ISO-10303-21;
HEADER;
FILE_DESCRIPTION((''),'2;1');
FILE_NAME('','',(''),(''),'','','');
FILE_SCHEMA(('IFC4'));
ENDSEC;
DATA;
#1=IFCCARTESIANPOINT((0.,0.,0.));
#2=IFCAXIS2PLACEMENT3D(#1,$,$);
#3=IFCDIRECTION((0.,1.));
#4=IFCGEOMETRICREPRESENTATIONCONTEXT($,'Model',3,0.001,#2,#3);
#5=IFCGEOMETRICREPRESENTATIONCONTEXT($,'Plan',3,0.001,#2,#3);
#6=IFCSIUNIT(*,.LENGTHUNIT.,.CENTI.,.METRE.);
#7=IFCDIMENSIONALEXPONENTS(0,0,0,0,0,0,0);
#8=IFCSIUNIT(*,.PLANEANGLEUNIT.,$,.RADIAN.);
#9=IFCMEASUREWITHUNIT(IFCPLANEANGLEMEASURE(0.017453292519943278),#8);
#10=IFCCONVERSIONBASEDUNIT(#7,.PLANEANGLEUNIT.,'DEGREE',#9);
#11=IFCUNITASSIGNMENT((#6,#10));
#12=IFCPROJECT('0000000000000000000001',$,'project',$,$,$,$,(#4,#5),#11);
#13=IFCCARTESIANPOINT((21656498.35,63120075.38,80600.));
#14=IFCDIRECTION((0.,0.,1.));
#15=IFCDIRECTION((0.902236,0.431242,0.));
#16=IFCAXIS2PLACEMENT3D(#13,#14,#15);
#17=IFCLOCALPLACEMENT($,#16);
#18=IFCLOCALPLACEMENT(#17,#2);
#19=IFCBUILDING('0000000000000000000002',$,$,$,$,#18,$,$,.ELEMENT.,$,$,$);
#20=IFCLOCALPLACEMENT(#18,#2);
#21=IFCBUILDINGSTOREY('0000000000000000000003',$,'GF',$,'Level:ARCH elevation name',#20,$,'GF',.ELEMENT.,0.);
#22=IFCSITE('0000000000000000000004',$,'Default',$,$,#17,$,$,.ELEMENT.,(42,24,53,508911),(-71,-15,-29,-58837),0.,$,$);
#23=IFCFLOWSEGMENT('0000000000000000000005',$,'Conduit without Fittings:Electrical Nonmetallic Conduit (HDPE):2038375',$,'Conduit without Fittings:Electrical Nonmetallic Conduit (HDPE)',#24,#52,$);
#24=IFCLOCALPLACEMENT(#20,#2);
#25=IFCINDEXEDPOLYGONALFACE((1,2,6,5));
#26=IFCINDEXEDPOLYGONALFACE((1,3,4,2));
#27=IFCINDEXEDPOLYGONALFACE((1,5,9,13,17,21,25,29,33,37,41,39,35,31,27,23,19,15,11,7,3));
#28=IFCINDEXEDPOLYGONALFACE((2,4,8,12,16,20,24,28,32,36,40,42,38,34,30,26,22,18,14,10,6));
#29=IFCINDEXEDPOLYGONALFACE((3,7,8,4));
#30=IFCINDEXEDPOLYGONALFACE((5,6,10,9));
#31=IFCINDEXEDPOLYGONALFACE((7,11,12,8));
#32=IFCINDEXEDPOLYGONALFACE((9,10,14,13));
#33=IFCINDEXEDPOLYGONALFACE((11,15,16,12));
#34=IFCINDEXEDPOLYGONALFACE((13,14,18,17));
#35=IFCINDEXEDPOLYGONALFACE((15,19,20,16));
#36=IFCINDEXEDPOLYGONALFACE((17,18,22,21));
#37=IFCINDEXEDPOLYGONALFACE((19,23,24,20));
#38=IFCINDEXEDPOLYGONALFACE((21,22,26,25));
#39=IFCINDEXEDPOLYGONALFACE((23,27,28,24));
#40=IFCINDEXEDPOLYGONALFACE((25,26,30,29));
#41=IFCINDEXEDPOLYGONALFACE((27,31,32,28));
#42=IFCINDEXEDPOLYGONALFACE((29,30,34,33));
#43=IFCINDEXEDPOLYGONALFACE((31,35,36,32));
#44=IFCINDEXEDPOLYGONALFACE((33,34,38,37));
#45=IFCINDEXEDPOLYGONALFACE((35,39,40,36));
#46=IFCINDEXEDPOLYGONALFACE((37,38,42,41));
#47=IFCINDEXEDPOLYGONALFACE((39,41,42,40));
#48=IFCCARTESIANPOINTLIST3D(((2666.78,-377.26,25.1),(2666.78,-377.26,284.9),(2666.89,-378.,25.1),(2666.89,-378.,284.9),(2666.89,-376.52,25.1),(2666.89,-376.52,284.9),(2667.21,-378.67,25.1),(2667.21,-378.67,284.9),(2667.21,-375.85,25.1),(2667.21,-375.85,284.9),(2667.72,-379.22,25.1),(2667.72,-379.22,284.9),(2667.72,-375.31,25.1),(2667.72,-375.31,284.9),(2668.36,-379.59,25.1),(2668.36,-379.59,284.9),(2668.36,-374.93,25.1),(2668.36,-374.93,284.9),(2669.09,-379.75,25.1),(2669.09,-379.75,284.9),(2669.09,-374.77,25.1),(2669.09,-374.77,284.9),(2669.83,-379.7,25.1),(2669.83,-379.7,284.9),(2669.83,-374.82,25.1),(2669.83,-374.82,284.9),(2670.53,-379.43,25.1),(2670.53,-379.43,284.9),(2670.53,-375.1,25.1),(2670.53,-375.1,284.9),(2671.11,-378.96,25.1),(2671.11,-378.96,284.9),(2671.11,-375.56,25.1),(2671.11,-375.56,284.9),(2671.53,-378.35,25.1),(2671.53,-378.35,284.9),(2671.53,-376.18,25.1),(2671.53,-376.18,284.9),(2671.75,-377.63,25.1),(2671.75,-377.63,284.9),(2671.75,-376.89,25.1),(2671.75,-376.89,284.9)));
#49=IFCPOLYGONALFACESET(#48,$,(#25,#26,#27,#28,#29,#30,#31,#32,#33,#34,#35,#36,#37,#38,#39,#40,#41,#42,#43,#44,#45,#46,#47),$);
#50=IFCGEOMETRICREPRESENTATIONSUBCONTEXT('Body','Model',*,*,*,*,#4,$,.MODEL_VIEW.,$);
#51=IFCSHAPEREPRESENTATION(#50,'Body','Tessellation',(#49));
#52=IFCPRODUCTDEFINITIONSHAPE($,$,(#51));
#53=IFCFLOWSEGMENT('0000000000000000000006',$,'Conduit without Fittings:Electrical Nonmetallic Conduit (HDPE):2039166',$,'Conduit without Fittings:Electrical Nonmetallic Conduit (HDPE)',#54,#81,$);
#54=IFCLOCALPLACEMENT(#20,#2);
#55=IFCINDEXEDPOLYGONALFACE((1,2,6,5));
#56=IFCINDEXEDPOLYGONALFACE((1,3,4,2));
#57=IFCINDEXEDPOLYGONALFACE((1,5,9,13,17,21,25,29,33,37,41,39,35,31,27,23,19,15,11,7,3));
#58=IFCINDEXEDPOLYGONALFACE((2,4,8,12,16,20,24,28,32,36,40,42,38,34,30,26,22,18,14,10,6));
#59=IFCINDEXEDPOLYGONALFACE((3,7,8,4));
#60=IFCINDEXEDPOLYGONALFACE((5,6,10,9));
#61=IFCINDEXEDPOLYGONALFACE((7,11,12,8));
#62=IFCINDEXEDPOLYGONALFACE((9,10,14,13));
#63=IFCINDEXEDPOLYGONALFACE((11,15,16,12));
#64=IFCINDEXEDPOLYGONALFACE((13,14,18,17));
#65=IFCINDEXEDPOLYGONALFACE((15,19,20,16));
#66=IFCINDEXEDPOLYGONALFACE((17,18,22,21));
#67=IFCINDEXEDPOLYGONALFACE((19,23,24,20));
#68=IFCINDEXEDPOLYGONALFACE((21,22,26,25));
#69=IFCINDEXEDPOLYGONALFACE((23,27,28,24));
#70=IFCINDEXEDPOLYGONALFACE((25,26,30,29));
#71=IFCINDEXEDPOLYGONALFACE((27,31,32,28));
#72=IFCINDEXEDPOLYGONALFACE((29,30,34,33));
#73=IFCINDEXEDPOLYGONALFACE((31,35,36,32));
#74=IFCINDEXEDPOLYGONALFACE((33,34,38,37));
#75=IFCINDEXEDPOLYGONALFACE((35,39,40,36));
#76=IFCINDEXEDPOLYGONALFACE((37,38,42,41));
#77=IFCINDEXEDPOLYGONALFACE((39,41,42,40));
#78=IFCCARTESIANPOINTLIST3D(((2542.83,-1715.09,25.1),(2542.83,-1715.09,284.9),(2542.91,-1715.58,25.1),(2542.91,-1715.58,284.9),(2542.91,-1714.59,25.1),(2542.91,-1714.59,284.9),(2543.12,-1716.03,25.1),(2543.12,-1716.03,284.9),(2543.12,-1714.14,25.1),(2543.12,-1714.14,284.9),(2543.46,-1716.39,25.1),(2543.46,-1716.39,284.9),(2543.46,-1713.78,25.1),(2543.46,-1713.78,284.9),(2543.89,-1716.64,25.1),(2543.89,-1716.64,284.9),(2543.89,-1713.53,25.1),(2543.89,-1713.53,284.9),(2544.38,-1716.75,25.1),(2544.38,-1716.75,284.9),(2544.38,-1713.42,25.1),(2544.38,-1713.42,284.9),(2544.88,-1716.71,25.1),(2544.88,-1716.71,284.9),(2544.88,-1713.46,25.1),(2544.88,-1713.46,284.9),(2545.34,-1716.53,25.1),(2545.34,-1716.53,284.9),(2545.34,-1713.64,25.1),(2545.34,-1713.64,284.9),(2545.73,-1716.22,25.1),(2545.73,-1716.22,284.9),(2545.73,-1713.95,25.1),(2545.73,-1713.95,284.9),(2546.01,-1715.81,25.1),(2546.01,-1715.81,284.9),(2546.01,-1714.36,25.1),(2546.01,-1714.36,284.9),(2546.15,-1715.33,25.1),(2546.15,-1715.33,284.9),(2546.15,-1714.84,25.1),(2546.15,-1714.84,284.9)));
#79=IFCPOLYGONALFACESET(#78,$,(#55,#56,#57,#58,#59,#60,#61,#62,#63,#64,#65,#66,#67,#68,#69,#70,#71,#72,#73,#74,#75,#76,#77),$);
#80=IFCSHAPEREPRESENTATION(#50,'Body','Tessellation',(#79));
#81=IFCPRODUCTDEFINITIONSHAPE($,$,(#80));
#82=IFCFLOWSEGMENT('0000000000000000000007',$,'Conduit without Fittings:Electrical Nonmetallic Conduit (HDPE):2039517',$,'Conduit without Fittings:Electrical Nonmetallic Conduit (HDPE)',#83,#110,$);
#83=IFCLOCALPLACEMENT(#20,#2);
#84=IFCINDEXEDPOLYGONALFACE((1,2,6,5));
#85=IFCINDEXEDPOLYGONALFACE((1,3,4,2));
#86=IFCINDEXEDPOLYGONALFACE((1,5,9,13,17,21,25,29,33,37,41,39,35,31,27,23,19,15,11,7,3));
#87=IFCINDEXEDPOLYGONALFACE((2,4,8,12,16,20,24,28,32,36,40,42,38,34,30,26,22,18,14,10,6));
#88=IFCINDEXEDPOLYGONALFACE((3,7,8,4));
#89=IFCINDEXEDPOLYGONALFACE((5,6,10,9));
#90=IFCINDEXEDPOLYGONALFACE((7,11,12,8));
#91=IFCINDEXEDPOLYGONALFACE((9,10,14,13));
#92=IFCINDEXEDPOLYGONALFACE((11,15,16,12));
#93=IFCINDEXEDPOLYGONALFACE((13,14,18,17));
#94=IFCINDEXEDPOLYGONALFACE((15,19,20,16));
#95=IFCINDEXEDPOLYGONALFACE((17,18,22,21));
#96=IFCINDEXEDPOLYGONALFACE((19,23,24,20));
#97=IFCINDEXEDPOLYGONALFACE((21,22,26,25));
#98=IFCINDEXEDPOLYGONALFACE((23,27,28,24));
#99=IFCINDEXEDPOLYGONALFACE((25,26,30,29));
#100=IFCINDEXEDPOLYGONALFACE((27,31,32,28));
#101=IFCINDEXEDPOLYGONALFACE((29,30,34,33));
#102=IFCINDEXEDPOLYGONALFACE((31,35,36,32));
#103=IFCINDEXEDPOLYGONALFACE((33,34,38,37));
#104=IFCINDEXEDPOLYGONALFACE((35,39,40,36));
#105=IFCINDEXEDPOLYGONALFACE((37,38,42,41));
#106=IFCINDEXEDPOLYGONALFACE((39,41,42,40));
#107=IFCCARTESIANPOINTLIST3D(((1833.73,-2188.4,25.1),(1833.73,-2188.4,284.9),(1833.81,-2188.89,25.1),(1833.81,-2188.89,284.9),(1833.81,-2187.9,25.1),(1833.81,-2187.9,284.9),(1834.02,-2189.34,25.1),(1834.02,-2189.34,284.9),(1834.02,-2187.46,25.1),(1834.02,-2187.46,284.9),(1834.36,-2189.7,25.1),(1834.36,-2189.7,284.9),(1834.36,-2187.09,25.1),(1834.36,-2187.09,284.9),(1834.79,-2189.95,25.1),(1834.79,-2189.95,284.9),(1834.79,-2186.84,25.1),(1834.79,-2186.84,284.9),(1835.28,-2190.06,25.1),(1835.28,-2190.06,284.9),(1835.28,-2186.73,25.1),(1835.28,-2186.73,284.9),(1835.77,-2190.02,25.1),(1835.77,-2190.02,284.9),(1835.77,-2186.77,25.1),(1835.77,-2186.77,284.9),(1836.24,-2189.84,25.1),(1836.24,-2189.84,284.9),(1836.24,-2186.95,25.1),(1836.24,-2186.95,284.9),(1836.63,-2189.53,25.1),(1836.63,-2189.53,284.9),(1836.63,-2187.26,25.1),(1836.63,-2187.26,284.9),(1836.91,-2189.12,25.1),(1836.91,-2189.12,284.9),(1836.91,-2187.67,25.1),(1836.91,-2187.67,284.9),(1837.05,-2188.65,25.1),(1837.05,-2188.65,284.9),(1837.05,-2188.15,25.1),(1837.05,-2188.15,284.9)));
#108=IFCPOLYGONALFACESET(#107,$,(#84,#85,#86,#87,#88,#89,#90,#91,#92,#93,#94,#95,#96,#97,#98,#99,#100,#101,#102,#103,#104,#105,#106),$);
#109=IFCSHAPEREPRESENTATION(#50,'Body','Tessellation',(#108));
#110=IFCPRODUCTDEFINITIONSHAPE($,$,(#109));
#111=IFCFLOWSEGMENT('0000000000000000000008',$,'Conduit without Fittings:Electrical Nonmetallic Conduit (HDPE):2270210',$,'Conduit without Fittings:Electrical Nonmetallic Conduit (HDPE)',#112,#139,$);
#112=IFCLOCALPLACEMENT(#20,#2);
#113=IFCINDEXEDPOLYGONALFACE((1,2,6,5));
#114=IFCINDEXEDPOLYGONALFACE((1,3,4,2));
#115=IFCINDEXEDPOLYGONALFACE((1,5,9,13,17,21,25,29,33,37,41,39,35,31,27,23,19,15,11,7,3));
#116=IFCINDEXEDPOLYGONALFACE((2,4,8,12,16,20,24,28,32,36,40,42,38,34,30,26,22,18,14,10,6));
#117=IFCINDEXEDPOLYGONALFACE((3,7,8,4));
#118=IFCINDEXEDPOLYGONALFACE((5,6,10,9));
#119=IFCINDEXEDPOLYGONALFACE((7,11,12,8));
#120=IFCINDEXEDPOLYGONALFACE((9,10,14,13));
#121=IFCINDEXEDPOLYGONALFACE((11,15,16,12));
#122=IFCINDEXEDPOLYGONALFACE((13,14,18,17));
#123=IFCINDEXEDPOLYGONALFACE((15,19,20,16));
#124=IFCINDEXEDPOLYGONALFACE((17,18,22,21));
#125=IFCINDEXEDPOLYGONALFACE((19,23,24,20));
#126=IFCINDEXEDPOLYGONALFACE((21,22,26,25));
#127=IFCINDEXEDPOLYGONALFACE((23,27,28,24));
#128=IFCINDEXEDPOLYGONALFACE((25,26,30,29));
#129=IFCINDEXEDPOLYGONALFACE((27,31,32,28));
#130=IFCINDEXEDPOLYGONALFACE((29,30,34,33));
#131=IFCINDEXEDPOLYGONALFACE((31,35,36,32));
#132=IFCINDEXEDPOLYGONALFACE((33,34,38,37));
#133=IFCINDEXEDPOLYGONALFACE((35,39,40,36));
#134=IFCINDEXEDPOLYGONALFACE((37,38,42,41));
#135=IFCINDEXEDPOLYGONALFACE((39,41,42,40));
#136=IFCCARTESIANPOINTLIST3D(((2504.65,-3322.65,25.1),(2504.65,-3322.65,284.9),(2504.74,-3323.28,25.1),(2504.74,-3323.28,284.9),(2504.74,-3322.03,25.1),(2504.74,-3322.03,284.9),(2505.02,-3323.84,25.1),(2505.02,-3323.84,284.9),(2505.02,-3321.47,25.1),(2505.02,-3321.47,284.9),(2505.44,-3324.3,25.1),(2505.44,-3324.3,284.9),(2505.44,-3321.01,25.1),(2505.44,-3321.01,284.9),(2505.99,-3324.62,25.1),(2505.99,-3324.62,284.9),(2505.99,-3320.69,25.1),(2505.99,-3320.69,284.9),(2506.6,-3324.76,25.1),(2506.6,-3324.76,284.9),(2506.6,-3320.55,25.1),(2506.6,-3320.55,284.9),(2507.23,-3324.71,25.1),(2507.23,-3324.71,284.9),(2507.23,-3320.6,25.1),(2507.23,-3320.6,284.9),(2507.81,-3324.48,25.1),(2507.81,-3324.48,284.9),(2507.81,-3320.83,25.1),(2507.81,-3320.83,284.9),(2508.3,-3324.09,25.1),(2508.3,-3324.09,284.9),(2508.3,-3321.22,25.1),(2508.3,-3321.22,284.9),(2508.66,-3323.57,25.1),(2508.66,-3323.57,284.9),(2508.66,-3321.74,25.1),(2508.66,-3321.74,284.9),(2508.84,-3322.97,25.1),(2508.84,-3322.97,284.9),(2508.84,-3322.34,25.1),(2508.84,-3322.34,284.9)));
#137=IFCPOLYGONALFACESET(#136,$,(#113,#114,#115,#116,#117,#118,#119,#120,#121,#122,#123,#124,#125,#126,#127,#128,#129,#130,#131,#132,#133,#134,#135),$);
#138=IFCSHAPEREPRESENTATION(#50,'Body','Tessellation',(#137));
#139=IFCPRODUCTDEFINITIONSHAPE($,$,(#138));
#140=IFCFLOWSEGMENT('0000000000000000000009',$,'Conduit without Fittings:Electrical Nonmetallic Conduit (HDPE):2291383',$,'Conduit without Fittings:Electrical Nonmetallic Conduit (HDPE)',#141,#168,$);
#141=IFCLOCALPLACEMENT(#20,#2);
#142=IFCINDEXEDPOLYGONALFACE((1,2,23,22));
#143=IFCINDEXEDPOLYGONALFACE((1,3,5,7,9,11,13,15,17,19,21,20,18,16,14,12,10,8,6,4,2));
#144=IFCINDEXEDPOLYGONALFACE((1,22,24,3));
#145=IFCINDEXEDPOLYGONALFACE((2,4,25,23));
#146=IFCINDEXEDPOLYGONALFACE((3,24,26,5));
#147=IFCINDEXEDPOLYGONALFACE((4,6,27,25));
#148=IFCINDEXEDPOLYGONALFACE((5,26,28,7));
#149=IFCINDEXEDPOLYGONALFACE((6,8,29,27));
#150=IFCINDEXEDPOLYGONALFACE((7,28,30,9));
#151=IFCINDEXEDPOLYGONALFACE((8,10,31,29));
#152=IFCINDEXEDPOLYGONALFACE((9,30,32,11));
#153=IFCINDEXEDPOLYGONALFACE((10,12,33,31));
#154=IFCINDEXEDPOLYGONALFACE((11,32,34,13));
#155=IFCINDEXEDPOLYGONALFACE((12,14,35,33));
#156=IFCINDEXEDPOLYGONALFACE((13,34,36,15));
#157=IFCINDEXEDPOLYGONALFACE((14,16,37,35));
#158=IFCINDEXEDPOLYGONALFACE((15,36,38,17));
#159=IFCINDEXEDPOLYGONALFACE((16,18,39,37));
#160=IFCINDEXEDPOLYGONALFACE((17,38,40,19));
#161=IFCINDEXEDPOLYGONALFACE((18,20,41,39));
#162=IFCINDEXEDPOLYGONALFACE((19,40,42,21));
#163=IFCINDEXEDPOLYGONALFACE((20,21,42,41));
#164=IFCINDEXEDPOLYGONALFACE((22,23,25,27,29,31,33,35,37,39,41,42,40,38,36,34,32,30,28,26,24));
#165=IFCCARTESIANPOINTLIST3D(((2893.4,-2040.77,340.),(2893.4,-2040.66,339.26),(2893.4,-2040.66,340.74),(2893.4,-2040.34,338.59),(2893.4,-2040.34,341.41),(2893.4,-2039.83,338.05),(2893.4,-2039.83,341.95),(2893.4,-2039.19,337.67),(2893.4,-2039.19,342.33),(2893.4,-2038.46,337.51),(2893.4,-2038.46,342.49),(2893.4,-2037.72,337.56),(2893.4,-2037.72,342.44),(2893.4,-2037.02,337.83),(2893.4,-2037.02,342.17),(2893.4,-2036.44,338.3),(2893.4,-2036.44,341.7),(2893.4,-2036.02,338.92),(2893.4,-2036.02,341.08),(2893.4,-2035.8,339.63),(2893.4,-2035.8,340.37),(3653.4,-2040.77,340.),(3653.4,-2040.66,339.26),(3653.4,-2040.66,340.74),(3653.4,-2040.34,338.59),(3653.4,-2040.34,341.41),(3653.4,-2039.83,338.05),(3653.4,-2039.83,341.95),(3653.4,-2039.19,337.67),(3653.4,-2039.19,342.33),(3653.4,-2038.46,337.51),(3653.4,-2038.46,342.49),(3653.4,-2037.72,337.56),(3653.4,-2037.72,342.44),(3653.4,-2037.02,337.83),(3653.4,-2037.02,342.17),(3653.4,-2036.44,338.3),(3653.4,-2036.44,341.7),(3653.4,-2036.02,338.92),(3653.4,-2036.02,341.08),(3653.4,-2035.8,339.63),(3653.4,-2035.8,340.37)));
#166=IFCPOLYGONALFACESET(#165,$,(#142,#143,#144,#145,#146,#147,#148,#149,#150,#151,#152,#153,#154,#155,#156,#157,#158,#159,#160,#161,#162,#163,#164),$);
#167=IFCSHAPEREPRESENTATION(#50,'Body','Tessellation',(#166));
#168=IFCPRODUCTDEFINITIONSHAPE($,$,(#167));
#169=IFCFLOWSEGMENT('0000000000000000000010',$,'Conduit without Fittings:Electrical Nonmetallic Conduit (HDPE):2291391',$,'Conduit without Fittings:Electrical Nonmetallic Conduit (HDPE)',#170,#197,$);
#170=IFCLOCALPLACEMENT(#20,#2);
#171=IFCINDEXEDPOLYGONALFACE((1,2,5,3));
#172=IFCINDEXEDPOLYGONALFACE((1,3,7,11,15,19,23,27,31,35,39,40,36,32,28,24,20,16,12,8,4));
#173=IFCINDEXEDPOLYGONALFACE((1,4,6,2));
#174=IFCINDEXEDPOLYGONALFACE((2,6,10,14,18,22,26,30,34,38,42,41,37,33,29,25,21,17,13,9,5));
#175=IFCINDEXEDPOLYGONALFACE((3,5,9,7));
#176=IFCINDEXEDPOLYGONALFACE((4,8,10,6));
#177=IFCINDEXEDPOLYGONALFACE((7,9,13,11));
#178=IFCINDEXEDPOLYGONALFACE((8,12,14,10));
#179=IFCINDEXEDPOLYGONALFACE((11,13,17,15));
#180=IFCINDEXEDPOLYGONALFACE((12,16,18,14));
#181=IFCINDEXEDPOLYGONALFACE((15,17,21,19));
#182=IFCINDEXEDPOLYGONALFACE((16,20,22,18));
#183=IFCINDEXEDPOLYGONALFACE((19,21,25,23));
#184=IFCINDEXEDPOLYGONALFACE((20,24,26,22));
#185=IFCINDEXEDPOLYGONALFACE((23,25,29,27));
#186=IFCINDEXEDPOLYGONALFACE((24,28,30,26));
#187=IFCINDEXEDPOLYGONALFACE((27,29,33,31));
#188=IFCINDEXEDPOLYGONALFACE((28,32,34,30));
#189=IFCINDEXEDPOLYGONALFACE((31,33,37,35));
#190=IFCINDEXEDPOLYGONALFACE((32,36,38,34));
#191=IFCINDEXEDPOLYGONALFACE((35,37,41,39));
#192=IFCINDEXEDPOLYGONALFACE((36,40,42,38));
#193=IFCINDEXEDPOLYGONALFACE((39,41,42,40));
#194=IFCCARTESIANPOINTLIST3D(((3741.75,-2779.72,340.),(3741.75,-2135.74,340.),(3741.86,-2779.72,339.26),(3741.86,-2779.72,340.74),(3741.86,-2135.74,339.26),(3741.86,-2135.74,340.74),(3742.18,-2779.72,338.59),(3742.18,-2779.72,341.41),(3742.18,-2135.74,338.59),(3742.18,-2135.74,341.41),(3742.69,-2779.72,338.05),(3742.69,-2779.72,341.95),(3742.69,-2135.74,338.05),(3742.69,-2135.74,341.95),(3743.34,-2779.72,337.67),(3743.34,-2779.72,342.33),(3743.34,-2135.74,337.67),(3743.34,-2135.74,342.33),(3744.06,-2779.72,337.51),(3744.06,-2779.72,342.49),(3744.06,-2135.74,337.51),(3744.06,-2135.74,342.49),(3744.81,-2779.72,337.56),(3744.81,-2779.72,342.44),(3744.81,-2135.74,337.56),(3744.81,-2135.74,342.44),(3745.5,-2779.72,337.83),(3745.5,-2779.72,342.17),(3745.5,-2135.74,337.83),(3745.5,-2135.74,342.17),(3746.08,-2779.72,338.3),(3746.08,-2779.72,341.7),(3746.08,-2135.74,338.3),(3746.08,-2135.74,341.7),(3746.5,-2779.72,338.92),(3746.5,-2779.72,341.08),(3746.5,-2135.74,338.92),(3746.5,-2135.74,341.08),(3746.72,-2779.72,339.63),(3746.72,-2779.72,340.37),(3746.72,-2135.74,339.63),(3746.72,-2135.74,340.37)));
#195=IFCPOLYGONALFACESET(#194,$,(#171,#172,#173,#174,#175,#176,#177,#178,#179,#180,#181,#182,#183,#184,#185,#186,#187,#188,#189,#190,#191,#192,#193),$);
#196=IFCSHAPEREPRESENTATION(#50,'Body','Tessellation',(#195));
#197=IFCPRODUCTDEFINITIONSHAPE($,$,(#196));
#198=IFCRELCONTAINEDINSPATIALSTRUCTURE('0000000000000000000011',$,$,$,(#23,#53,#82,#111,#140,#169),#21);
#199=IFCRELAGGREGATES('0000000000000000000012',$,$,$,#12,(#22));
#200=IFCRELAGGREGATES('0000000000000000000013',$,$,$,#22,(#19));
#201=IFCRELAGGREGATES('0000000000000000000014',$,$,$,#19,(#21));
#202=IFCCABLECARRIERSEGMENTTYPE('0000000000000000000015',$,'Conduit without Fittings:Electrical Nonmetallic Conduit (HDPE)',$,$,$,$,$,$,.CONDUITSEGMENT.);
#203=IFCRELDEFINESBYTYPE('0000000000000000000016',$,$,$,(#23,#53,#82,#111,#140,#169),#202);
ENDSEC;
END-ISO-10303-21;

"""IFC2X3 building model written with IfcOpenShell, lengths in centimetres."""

from ifc_helpers import new_model, entity, si_unit, converted_unit, direction, frame, frame_2d, origin, origin_2d_with_axis, place, context, subcontext, project, spatial, circle, extrude, type_object, element, save


model = new_model("IFC2X3")

# Units and contexts
model_context = context("Model", 3, precision=0.001, world=origin(), true_north=direction((0.0, 1.0)))
plan_context = context("Plan", 3, precision=0.001, world=origin(), true_north=direction((0.0, 1.0)))
body_context = subcontext(model_context, "Body", "Model", "MODEL_VIEW")
ifc_project = project(units=[si_unit("LENGTHUNIT", "METRE", prefix="CENTI"), converted_unit("PLANEANGLEUNIT", "DEGREE", entity("IfcPlaneAngleMeasure", 0.017453292519943278), si_unit("PLANEANGLEUNIT", "RADIAN"), dimensions=[0, 0, 0, 0, 0, 0, 0])], contexts=[model_context, plan_context])

# Site, building, storey
site_placement = place(None, frame((21656498.35, 63120075.38, 80600.0), z_axis=(0.0, 0.0, 1.0), x_axis=(0.902236, 0.431242, 0.0)))
site = spatial("IfcSite", under=ifc_project, at=site_placement, Name="Default", CompositionType="ELEMENT", RefLatitude=(42, 24, 53, 508911), RefLongitude=(-71, -15, -29, -58837), RefElevation=0.0)
building_placement = place(site_placement, origin())
building = spatial("IfcBuilding", under=site, at=building_placement, CompositionType="ELEMENT")
storey_placement = place(building_placement, origin())
storey = spatial("IfcBuildingStorey", under=building, at=storey_placement, Name="GF", ObjectType="Level:ARCH elevation name", LongName="GF", CompositionType="ELEMENT", Elevation=0.0)

# Flow segments
cable_carrier_segment_type_1 = type_object("IfcCableCarrierSegmentType", Name="Conduit without Fittings:Electrical Nonmetallic Conduit (HDPE)", PredefinedType="CONDUITSEGMENT")
flow_segment_1_placement = place(storey_placement, origin())
element("IfcFlowSegment", 1, at=flow_segment_1_placement, inside=storey, type_object=cable_carrier_segment_type_1, Name="Conduit without Fittings:Electrical Nonmetallic Conduit (HDPE):2038375", ObjectType="Conduit without Fittings:Electrical Nonmetallic Conduit (HDPE)", context=body_context, shape_type="SweptSolid", body=[
    extrude(circle(Radius=2.5, at=frame_2d((0.0, 0.0), x_axis=(1.0, 0.0))), frame((2669.28, -377.26, 25.1), z_axis=(0.0, 0.0, 1.0), x_axis=(-1.0, 0.0, 0.0)), (0.0, 0.0, 1.0), 259.8),
])
flow_segment_2_placement = place(storey_placement, origin())
element("IfcFlowSegment", 2, at=flow_segment_2_placement, inside=storey, type_object=cable_carrier_segment_type_1, Name="Conduit without Fittings:Electrical Nonmetallic Conduit (HDPE):2039166", ObjectType="Conduit without Fittings:Electrical Nonmetallic Conduit (HDPE)", context=body_context, shape_type="SweptSolid", body=[
    extrude(circle(Radius=1.67, at=origin_2d_with_axis()), frame((2544.5, -1715.09, 25.1), z_axis=(0.0, 0.0, 1.0), x_axis=(-1.0, 0.0, 0.0)), (0.0, 0.0, 1.0), 259.8),
])
flow_segment_3_placement = place(storey_placement, origin())
element("IfcFlowSegment", 3, at=flow_segment_3_placement, inside=storey, type_object=cable_carrier_segment_type_1, Name="Conduit without Fittings:Electrical Nonmetallic Conduit (HDPE):2039517", ObjectType="Conduit without Fittings:Electrical Nonmetallic Conduit (HDPE)", context=body_context, shape_type="SweptSolid", body=[
    extrude(circle(Radius=1.67, at=frame_2d((0.0, 0.0), x_axis=(1.0, 0.0))), frame((1835.4, -2188.4, 25.1), z_axis=(0.0, 0.0, 1.0), x_axis=(-1.0, 0.0, 0.0)), (0.0, 0.0, 1.0), 259.8),
])
flow_segment_4_placement = place(storey_placement, origin())
element("IfcFlowSegment", 4, at=flow_segment_4_placement, inside=storey, type_object=cable_carrier_segment_type_1, Name="Conduit without Fittings:Electrical Nonmetallic Conduit (HDPE):2270210", ObjectType="Conduit without Fittings:Electrical Nonmetallic Conduit (HDPE)", context=body_context, shape_type="SweptSolid", body=[
    extrude(circle(Radius=2.11, at=origin_2d_with_axis()), frame((2506.76, -3322.65, 25.1), z_axis=(0.0, 0.0, 1.0), x_axis=(-1.0, 0.0, 0.0)), (0.0, 0.0, 1.0), 259.8),
])
flow_segment_5_placement = place(storey_placement, origin())
element("IfcFlowSegment", 5, at=flow_segment_5_placement, inside=storey, type_object=cable_carrier_segment_type_1, Name="Conduit without Fittings:Electrical Nonmetallic Conduit (HDPE):2291383", ObjectType="Conduit without Fittings:Electrical Nonmetallic Conduit (HDPE)", context=body_context, shape_type="SweptSolid", body=[
    extrude(circle(Radius=2.5, at=origin_2d_with_axis()), frame((2893.4, -2038.27, 340.0), z_axis=(1.0, 0.0, 0.0), x_axis=(0.0, -1.0, 0.0)), (0.0, 0.0, 1.0), 760.0),
])
flow_segment_6_placement = place(storey_placement, origin())
element("IfcFlowSegment", 6, at=flow_segment_6_placement, inside=storey, type_object=cable_carrier_segment_type_1, Name="Conduit without Fittings:Electrical Nonmetallic Conduit (HDPE):2291391", ObjectType="Conduit without Fittings:Electrical Nonmetallic Conduit (HDPE)", context=body_context, shape_type="SweptSolid", body=[
    extrude(circle(Radius=2.5, at=frame_2d((0.0, 0.0), x_axis=(1.0, 0.0))), frame((3744.25, -2779.72, 340.0), z_axis=(0.0, 1.0, 0.0), x_axis=(-1.0, 0.0, 0.0)), (0.0, 0.0, 1.0), 643.97),
])

save(model, "model.ifc")
